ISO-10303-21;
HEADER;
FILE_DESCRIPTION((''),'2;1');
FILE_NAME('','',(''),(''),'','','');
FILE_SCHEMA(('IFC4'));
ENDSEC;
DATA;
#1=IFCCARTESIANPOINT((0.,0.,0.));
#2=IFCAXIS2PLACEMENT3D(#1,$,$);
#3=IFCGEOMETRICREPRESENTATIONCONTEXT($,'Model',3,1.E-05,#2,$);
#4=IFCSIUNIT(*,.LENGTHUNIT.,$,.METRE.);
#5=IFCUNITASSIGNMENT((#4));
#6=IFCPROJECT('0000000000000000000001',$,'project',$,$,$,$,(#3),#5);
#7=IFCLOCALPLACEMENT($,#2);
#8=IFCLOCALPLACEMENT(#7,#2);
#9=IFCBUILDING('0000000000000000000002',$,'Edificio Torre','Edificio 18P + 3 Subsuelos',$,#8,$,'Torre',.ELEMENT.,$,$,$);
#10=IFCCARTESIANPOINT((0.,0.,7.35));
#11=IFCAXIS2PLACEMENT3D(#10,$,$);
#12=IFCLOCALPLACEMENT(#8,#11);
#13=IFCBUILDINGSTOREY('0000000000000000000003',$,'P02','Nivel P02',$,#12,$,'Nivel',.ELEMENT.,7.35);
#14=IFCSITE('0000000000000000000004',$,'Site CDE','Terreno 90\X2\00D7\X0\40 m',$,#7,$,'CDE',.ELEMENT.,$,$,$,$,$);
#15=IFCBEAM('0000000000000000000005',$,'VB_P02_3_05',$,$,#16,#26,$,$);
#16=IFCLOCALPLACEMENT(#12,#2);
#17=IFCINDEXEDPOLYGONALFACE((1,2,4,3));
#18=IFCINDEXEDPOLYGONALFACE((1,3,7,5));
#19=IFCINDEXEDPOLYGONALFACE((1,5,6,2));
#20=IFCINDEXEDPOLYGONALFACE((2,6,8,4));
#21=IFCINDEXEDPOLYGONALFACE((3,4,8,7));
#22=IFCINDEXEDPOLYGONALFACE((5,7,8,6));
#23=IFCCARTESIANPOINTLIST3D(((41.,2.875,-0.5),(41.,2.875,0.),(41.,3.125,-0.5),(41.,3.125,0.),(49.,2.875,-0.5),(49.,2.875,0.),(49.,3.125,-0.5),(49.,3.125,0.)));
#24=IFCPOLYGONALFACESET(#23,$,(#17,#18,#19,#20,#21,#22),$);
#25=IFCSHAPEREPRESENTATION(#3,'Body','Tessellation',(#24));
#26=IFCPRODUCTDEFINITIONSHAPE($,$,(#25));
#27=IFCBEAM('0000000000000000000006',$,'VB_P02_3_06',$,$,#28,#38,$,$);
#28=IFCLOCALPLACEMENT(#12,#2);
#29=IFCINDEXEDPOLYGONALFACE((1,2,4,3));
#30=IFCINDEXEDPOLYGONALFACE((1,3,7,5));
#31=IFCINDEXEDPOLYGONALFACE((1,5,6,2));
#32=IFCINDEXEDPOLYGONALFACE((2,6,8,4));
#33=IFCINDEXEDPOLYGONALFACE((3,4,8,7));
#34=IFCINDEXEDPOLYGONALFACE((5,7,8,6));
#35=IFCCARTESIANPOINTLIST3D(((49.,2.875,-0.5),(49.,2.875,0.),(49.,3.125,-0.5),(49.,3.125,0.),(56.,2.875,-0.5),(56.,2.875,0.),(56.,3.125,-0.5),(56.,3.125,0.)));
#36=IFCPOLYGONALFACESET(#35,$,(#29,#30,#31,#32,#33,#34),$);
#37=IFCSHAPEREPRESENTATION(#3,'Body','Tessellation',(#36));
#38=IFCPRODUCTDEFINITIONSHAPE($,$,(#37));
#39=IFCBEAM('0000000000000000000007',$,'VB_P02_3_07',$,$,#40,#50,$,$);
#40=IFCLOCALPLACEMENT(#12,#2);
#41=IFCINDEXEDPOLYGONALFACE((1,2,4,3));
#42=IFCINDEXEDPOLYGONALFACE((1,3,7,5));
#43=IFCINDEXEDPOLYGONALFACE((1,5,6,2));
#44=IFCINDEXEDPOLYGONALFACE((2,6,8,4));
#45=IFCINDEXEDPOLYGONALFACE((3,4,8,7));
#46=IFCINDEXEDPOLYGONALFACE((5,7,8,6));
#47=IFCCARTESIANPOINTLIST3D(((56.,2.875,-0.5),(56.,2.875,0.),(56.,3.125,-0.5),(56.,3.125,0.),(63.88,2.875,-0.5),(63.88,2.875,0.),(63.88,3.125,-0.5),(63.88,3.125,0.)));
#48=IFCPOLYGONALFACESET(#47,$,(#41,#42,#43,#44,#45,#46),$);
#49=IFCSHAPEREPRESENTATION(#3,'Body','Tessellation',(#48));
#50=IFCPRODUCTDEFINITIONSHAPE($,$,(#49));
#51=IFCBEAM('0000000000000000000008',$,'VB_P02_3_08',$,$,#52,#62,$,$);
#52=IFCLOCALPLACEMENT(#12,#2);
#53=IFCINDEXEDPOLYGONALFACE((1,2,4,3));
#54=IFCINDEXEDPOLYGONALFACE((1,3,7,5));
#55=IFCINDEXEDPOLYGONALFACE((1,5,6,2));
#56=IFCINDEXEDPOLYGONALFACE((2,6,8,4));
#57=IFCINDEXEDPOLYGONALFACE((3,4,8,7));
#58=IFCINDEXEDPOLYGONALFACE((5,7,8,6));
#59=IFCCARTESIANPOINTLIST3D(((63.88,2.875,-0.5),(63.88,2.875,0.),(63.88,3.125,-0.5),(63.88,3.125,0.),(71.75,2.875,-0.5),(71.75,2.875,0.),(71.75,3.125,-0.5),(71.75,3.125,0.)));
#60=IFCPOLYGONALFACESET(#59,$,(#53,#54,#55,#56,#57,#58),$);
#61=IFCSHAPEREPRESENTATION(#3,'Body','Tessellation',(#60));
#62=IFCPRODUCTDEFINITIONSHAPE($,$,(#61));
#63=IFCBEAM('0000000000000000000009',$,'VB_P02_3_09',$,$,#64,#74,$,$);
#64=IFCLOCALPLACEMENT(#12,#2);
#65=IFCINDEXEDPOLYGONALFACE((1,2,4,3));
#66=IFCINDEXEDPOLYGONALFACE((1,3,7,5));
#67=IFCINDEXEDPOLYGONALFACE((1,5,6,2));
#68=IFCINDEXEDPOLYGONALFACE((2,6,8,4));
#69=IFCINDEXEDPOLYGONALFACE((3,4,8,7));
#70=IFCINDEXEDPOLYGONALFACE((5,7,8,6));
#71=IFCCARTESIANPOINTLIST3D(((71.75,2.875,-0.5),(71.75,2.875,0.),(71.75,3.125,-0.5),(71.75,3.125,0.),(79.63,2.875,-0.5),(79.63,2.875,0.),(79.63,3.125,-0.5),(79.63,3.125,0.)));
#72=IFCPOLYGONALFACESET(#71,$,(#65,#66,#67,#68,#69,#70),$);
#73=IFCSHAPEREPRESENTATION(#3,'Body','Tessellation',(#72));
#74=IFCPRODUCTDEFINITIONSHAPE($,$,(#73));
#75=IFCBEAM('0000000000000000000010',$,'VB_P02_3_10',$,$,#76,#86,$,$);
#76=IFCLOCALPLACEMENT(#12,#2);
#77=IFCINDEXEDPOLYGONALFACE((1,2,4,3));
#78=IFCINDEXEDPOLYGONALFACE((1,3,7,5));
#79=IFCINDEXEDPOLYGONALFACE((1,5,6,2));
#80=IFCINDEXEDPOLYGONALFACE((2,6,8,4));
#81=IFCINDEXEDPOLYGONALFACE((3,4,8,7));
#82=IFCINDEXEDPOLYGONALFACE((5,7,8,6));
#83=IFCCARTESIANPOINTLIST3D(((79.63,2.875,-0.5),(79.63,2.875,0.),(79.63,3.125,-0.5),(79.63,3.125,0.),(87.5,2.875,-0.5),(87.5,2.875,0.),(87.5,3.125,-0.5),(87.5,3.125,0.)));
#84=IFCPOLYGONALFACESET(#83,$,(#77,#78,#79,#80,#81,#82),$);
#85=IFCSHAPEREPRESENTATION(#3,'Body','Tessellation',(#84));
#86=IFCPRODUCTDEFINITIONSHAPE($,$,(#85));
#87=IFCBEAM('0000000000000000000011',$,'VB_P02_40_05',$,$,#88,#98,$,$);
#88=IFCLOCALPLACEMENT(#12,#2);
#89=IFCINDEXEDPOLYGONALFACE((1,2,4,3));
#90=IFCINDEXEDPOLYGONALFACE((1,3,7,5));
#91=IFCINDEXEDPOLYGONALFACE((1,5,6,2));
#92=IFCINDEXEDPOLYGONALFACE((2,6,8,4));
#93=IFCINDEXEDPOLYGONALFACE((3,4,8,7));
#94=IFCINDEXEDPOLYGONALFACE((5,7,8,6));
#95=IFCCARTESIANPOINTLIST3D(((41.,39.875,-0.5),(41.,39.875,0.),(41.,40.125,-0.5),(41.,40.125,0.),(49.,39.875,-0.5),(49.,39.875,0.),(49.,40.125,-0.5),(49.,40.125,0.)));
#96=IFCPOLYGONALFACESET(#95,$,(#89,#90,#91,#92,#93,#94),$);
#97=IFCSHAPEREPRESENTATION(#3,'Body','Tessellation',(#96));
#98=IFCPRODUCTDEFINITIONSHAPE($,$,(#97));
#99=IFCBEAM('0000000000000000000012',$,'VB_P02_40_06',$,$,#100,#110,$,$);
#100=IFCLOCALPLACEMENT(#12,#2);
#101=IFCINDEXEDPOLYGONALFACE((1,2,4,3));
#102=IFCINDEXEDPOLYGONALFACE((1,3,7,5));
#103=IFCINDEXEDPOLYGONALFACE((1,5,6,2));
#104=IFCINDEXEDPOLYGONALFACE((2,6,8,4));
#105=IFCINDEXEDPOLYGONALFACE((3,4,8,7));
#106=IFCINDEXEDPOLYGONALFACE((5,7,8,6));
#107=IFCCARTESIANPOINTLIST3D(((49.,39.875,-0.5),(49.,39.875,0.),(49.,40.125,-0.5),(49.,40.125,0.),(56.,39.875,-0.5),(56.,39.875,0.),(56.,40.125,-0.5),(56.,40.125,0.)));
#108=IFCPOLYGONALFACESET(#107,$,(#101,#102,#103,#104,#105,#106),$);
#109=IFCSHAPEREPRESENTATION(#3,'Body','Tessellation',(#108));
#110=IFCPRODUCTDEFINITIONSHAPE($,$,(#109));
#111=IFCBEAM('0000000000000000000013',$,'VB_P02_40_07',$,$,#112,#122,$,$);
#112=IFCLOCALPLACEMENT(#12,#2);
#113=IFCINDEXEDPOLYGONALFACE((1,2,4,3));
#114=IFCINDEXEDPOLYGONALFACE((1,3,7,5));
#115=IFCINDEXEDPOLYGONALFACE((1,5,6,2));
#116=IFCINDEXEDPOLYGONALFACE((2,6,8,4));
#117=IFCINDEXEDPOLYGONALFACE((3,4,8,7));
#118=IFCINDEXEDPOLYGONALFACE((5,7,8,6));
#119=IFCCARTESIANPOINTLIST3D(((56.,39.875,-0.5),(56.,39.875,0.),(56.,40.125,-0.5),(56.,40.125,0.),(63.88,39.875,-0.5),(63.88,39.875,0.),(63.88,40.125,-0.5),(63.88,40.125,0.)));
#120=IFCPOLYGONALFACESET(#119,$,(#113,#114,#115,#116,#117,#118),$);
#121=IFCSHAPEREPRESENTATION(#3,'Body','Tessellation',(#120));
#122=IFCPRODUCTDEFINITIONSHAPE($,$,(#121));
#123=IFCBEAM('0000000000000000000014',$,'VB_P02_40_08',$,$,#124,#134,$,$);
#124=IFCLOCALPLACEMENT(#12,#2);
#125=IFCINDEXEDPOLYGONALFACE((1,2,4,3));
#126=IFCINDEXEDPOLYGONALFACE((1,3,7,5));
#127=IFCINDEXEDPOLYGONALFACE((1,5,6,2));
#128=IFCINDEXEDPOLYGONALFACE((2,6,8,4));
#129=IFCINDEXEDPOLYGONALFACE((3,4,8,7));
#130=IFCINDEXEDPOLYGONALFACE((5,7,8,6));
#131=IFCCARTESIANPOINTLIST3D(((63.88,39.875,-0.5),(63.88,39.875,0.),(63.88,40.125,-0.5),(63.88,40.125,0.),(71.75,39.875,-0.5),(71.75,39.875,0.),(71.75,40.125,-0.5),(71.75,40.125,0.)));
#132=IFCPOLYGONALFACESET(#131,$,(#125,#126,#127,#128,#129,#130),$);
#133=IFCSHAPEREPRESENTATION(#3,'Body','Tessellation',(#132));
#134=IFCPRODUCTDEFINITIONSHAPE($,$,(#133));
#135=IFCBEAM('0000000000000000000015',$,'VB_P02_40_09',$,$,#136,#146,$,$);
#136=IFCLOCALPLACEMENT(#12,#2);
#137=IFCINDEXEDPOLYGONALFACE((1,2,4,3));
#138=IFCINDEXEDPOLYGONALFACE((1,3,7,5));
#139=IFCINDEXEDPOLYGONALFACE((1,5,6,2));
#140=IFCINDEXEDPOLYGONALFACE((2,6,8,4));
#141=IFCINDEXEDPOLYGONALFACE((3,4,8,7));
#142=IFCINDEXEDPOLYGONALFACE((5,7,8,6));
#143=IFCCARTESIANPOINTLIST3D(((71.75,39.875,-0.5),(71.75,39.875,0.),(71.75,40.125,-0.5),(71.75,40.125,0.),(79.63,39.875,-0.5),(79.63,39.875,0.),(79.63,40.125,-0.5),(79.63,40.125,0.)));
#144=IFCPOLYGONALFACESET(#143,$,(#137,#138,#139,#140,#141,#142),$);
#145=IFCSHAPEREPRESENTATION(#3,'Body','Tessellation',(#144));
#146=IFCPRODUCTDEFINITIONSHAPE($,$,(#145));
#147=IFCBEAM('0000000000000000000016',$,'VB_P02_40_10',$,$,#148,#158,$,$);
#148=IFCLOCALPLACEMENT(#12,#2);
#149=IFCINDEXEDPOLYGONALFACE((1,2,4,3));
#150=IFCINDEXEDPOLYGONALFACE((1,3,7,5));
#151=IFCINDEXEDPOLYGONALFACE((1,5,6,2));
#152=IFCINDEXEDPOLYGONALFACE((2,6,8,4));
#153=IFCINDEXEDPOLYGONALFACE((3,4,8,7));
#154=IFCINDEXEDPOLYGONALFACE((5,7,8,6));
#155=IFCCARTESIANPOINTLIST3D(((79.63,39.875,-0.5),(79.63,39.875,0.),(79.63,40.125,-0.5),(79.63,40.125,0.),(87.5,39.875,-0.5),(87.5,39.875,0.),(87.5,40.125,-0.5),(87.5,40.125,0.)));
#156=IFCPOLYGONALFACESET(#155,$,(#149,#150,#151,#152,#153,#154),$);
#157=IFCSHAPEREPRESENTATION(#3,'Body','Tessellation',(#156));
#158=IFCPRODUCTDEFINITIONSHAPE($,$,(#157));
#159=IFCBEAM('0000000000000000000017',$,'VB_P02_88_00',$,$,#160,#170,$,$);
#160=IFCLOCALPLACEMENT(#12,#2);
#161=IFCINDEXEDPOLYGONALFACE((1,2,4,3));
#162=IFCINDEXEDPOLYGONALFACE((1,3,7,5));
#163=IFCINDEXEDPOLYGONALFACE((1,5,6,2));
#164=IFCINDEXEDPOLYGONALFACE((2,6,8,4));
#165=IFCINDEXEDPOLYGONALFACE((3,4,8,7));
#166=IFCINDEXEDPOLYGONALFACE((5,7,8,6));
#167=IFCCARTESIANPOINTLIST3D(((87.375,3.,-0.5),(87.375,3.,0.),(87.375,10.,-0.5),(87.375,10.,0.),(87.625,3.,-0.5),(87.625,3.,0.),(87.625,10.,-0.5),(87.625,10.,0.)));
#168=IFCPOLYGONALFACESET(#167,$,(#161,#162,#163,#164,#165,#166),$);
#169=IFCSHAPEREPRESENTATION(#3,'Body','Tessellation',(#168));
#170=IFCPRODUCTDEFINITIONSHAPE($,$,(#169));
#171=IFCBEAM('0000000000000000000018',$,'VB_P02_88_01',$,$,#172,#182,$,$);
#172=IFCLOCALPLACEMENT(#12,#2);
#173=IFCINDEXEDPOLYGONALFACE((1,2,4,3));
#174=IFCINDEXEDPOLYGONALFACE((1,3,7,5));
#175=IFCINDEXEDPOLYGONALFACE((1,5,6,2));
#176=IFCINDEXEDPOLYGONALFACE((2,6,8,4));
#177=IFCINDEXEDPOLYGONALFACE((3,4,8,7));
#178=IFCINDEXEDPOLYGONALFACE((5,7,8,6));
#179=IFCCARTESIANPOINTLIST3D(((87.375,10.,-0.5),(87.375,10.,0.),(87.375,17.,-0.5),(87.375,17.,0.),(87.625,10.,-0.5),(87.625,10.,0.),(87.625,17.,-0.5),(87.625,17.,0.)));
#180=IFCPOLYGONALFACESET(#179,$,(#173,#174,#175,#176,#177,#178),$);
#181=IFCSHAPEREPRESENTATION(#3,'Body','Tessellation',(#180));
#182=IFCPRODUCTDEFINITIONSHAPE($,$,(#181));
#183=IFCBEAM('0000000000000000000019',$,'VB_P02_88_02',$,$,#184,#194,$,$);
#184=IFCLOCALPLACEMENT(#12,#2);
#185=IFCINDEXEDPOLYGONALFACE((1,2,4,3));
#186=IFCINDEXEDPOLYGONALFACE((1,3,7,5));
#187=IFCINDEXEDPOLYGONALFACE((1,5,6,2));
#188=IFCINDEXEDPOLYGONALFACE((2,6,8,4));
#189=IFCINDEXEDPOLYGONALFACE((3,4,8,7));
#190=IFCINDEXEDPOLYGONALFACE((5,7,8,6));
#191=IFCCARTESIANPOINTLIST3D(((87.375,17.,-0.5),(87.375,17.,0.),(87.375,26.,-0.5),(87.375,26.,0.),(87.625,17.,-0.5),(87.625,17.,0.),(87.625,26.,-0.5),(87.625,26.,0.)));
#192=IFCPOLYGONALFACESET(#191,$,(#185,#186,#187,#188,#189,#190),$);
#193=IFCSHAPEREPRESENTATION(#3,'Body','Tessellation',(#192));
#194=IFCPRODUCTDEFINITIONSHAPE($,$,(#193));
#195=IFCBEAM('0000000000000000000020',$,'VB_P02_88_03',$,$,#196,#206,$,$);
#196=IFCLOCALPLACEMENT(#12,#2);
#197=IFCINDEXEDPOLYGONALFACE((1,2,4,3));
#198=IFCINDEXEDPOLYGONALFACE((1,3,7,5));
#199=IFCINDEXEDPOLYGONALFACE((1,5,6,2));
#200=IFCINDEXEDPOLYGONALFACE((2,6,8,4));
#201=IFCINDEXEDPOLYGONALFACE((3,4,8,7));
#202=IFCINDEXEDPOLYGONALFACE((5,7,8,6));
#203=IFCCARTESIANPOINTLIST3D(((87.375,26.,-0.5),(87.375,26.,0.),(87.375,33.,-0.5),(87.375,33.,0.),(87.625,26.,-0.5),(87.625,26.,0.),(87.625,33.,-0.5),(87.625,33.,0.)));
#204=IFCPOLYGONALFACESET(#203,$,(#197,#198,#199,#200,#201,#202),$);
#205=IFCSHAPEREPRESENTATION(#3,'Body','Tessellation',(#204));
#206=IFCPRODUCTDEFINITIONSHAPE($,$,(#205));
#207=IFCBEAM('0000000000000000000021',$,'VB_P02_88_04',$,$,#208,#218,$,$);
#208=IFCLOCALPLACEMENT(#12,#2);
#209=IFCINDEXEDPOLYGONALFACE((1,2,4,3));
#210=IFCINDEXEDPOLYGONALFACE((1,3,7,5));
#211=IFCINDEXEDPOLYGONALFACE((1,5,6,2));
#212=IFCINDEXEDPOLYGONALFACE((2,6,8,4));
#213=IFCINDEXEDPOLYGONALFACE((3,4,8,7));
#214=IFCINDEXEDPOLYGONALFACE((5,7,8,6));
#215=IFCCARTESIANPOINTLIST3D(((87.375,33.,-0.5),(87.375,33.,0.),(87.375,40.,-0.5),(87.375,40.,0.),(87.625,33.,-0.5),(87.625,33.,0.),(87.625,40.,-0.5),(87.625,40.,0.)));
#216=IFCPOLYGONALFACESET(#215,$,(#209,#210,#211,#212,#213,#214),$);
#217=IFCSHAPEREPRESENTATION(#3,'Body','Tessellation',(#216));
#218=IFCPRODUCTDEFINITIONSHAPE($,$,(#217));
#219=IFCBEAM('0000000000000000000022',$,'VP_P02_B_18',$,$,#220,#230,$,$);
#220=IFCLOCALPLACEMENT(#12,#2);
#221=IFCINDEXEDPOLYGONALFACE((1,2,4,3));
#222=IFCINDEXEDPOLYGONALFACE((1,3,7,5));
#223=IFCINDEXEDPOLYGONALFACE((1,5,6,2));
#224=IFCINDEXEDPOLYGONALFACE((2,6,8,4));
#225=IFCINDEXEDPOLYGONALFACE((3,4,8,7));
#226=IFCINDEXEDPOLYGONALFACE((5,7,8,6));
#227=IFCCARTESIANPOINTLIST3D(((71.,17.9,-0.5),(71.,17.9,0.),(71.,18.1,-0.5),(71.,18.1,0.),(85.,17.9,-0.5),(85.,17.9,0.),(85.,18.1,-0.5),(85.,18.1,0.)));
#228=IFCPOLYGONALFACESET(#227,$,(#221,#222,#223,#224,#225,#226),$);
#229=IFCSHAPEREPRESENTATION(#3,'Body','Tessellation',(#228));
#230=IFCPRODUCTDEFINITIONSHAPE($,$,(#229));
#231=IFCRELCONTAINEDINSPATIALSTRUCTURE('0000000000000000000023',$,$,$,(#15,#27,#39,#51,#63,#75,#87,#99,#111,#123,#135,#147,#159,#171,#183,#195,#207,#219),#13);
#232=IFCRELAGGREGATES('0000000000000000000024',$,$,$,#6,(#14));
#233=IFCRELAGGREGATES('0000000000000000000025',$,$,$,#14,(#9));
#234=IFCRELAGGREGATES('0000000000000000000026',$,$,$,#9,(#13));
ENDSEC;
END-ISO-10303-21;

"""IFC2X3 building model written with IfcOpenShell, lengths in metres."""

from ifc_helpers import new_model, si_unit, frame, origin, origin_2d, place, context, project, spatial, rectangle, extrude, element, save


model = new_model("IFC2X3")

# Units and contexts
model_context = context("Model", 3, precision=1e-05, world=origin())
ifc_project = project(units=[si_unit("LENGTHUNIT", "METRE")], contexts=[model_context])

# Site, building, storey
site_placement = place(None, origin())
site = spatial("IfcSite", under=ifc_project, at=site_placement, Name="Site CDE", Description="Terreno 90×40 m", LongName="CDE", CompositionType="ELEMENT")
building_placement = place(site_placement, origin())
building = spatial("IfcBuilding", under=site, at=building_placement, Name="Edificio Torre", Description="Edificio 18P + 3 Subsuelos", LongName="Torre", CompositionType="ELEMENT")
storey_placement = place(building_placement, frame((0.0, 0.0, 7.35)))
storey = spatial("IfcBuildingStorey", under=building, at=storey_placement, Name="P02", Description="Nivel P02", LongName="Nivel", CompositionType="ELEMENT", Elevation=7.35)

# Beams
beam_1_placement = place(storey_placement, frame((45.0, 3.0, -0.5)))
element("IfcBeam", 1, at=beam_1_placement, inside=storey, Name="VB_P02_3_05", context=model_context, shape_type="SweptSolid", body=[
    extrude(rectangle(XDim=8.0, YDim=0.25, at=origin_2d()), origin(), (0.0, 0.0, 1.0), 0.5),
])
beam_2_placement = place(storey_placement, frame((52.5, 3.0, -0.5)))
element("IfcBeam", 2, at=beam_2_placement, inside=storey, Name="VB_P02_3_06", context=model_context, shape_type="SweptSolid", body=[
    extrude(rectangle(XDim=7.0, YDim=0.25, at=origin_2d()), origin(), (0.0, 0.0, 1.0), 0.5),
])
beam_3_placement = place(storey_placement, frame((59.94, 3.0, -0.5)))
element("IfcBeam", 3, at=beam_3_placement, inside=storey, Name="VB_P02_3_07", context=model_context, shape_type="SweptSolid", body=[
    extrude(rectangle(XDim=7.88, YDim=0.25, at=origin_2d()), origin(), (0.0, 0.0, 1.0), 0.5),
])
beam_4_placement = place(storey_placement, frame((67.815, 3.0, -0.5)))
element("IfcBeam", 4, at=beam_4_placement, inside=storey, Name="VB_P02_3_08", context=model_context, shape_type="SweptSolid", body=[
    extrude(rectangle(XDim=7.87, YDim=0.25, at=origin_2d()), origin(), (0.0, 0.0, 1.0), 0.5),
])
beam_5_placement = place(storey_placement, frame((75.69, 3.0, -0.5)))
element("IfcBeam", 5, at=beam_5_placement, inside=storey, Name="VB_P02_3_09", context=model_context, shape_type="SweptSolid", body=[
    extrude(rectangle(XDim=7.88, YDim=0.25, at=origin_2d()), origin(), (0.0, 0.0, 1.0), 0.5),
])
beam_6_placement = place(storey_placement, frame((83.565, 3.0, -0.5)))
element("IfcBeam", 6, at=beam_6_placement, inside=storey, Name="VB_P02_3_10", context=model_context, shape_type="SweptSolid", body=[
    extrude(rectangle(XDim=7.87, YDim=0.25, at=origin_2d()), origin(), (0.0, 0.0, 1.0), 0.5),
])
beam_7_placement = place(storey_placement, frame((45.0, 40.0, -0.5)))
element("IfcBeam", 7, at=beam_7_placement, inside=storey, Name="VB_P02_40_05", context=model_context, shape_type="SweptSolid", body=[
    extrude(rectangle(XDim=8.0, YDim=0.25, at=origin_2d()), origin(), (0.0, 0.0, 1.0), 0.5),
])
beam_8_placement = place(storey_placement, frame((52.5, 40.0, -0.5)))
element("IfcBeam", 8, at=beam_8_placement, inside=storey, Name="VB_P02_40_06", context=model_context, shape_type="SweptSolid", body=[
    extrude(rectangle(XDim=7.0, YDim=0.25, at=origin_2d()), origin(), (0.0, 0.0, 1.0), 0.5),
])
beam_9_placement = place(storey_placement, frame((59.94, 40.0, -0.5)))
element("IfcBeam", 9, at=beam_9_placement, inside=storey, Name="VB_P02_40_07", context=model_context, shape_type="SweptSolid", body=[
    extrude(rectangle(XDim=7.88, YDim=0.25, at=origin_2d()), origin(), (0.0, 0.0, 1.0), 0.5),
])
beam_10_placement = place(storey_placement, frame((67.815, 40.0, -0.5)))
element("IfcBeam", 10, at=beam_10_placement, inside=storey, Name="VB_P02_40_08", context=model_context, shape_type="SweptSolid", body=[
    extrude(rectangle(XDim=7.87, YDim=0.25, at=origin_2d()), origin(), (0.0, 0.0, 1.0), 0.5),
])
beam_11_placement = place(storey_placement, frame((75.69, 40.0, -0.5)))
element("IfcBeam", 11, at=beam_11_placement, inside=storey, Name="VB_P02_40_09", context=model_context, shape_type="SweptSolid", body=[
    extrude(rectangle(XDim=7.88, YDim=0.25, at=origin_2d()), origin(), (0.0, 0.0, 1.0), 0.5),
])
beam_12_placement = place(storey_placement, frame((83.565, 40.0, -0.5)))
element("IfcBeam", 12, at=beam_12_placement, inside=storey, Name="VB_P02_40_10", context=model_context, shape_type="SweptSolid", body=[
    extrude(rectangle(XDim=7.87, YDim=0.25, at=origin_2d()), origin(), (0.0, 0.0, 1.0), 0.5),
])
for number, where, name in (
    (13, (87.5, 6.5, -0.5), "VB_P02_88_00"),
    (14, (87.5, 13.5, -0.5), "VB_P02_88_01"),
):
    element("IfcBeam", number, at=place(storey_placement, frame(where)), inside=storey, Name=name, context=model_context, shape_type="SweptSolid", body=[
        extrude(rectangle(XDim=0.25, YDim=7.0, at=origin_2d()), origin(), (0.0, 0.0, 1.0), 0.5),
    ])
beam_13_placement = place(storey_placement, frame((87.5, 21.5, -0.5)))
element("IfcBeam", 15, at=beam_13_placement, inside=storey, Name="VB_P02_88_02", context=model_context, shape_type="SweptSolid", body=[
    extrude(rectangle(XDim=0.25, YDim=9.0, at=origin_2d()), origin(), (0.0, 0.0, 1.0), 0.5),
])
for number, where, name in (
    (16, (87.5, 29.5, -0.5), "VB_P02_88_03"),
    (17, (87.5, 36.5, -0.5), "VB_P02_88_04"),
):
    element("IfcBeam", number, at=place(storey_placement, frame(where)), inside=storey, Name=name, context=model_context, shape_type="SweptSolid", body=[
        extrude(rectangle(XDim=0.25, YDim=7.0, at=origin_2d()), origin(), (0.0, 0.0, 1.0), 0.5),
    ])
for number, where, name in (
    (18, (78.0, 18.0, -0.5), "VP_P02_B_18"),
):
    element("IfcBeam", number, at=place(storey_placement, frame(where)), inside=storey, Name=name, context=model_context, shape_type="SweptSolid", body=[
        extrude(rectangle(XDim=14.0, YDim=0.2, at=origin_2d()), origin(), (0.0, 0.0, 1.0), 0.5),
    ])

save(model, "model.ifc")
